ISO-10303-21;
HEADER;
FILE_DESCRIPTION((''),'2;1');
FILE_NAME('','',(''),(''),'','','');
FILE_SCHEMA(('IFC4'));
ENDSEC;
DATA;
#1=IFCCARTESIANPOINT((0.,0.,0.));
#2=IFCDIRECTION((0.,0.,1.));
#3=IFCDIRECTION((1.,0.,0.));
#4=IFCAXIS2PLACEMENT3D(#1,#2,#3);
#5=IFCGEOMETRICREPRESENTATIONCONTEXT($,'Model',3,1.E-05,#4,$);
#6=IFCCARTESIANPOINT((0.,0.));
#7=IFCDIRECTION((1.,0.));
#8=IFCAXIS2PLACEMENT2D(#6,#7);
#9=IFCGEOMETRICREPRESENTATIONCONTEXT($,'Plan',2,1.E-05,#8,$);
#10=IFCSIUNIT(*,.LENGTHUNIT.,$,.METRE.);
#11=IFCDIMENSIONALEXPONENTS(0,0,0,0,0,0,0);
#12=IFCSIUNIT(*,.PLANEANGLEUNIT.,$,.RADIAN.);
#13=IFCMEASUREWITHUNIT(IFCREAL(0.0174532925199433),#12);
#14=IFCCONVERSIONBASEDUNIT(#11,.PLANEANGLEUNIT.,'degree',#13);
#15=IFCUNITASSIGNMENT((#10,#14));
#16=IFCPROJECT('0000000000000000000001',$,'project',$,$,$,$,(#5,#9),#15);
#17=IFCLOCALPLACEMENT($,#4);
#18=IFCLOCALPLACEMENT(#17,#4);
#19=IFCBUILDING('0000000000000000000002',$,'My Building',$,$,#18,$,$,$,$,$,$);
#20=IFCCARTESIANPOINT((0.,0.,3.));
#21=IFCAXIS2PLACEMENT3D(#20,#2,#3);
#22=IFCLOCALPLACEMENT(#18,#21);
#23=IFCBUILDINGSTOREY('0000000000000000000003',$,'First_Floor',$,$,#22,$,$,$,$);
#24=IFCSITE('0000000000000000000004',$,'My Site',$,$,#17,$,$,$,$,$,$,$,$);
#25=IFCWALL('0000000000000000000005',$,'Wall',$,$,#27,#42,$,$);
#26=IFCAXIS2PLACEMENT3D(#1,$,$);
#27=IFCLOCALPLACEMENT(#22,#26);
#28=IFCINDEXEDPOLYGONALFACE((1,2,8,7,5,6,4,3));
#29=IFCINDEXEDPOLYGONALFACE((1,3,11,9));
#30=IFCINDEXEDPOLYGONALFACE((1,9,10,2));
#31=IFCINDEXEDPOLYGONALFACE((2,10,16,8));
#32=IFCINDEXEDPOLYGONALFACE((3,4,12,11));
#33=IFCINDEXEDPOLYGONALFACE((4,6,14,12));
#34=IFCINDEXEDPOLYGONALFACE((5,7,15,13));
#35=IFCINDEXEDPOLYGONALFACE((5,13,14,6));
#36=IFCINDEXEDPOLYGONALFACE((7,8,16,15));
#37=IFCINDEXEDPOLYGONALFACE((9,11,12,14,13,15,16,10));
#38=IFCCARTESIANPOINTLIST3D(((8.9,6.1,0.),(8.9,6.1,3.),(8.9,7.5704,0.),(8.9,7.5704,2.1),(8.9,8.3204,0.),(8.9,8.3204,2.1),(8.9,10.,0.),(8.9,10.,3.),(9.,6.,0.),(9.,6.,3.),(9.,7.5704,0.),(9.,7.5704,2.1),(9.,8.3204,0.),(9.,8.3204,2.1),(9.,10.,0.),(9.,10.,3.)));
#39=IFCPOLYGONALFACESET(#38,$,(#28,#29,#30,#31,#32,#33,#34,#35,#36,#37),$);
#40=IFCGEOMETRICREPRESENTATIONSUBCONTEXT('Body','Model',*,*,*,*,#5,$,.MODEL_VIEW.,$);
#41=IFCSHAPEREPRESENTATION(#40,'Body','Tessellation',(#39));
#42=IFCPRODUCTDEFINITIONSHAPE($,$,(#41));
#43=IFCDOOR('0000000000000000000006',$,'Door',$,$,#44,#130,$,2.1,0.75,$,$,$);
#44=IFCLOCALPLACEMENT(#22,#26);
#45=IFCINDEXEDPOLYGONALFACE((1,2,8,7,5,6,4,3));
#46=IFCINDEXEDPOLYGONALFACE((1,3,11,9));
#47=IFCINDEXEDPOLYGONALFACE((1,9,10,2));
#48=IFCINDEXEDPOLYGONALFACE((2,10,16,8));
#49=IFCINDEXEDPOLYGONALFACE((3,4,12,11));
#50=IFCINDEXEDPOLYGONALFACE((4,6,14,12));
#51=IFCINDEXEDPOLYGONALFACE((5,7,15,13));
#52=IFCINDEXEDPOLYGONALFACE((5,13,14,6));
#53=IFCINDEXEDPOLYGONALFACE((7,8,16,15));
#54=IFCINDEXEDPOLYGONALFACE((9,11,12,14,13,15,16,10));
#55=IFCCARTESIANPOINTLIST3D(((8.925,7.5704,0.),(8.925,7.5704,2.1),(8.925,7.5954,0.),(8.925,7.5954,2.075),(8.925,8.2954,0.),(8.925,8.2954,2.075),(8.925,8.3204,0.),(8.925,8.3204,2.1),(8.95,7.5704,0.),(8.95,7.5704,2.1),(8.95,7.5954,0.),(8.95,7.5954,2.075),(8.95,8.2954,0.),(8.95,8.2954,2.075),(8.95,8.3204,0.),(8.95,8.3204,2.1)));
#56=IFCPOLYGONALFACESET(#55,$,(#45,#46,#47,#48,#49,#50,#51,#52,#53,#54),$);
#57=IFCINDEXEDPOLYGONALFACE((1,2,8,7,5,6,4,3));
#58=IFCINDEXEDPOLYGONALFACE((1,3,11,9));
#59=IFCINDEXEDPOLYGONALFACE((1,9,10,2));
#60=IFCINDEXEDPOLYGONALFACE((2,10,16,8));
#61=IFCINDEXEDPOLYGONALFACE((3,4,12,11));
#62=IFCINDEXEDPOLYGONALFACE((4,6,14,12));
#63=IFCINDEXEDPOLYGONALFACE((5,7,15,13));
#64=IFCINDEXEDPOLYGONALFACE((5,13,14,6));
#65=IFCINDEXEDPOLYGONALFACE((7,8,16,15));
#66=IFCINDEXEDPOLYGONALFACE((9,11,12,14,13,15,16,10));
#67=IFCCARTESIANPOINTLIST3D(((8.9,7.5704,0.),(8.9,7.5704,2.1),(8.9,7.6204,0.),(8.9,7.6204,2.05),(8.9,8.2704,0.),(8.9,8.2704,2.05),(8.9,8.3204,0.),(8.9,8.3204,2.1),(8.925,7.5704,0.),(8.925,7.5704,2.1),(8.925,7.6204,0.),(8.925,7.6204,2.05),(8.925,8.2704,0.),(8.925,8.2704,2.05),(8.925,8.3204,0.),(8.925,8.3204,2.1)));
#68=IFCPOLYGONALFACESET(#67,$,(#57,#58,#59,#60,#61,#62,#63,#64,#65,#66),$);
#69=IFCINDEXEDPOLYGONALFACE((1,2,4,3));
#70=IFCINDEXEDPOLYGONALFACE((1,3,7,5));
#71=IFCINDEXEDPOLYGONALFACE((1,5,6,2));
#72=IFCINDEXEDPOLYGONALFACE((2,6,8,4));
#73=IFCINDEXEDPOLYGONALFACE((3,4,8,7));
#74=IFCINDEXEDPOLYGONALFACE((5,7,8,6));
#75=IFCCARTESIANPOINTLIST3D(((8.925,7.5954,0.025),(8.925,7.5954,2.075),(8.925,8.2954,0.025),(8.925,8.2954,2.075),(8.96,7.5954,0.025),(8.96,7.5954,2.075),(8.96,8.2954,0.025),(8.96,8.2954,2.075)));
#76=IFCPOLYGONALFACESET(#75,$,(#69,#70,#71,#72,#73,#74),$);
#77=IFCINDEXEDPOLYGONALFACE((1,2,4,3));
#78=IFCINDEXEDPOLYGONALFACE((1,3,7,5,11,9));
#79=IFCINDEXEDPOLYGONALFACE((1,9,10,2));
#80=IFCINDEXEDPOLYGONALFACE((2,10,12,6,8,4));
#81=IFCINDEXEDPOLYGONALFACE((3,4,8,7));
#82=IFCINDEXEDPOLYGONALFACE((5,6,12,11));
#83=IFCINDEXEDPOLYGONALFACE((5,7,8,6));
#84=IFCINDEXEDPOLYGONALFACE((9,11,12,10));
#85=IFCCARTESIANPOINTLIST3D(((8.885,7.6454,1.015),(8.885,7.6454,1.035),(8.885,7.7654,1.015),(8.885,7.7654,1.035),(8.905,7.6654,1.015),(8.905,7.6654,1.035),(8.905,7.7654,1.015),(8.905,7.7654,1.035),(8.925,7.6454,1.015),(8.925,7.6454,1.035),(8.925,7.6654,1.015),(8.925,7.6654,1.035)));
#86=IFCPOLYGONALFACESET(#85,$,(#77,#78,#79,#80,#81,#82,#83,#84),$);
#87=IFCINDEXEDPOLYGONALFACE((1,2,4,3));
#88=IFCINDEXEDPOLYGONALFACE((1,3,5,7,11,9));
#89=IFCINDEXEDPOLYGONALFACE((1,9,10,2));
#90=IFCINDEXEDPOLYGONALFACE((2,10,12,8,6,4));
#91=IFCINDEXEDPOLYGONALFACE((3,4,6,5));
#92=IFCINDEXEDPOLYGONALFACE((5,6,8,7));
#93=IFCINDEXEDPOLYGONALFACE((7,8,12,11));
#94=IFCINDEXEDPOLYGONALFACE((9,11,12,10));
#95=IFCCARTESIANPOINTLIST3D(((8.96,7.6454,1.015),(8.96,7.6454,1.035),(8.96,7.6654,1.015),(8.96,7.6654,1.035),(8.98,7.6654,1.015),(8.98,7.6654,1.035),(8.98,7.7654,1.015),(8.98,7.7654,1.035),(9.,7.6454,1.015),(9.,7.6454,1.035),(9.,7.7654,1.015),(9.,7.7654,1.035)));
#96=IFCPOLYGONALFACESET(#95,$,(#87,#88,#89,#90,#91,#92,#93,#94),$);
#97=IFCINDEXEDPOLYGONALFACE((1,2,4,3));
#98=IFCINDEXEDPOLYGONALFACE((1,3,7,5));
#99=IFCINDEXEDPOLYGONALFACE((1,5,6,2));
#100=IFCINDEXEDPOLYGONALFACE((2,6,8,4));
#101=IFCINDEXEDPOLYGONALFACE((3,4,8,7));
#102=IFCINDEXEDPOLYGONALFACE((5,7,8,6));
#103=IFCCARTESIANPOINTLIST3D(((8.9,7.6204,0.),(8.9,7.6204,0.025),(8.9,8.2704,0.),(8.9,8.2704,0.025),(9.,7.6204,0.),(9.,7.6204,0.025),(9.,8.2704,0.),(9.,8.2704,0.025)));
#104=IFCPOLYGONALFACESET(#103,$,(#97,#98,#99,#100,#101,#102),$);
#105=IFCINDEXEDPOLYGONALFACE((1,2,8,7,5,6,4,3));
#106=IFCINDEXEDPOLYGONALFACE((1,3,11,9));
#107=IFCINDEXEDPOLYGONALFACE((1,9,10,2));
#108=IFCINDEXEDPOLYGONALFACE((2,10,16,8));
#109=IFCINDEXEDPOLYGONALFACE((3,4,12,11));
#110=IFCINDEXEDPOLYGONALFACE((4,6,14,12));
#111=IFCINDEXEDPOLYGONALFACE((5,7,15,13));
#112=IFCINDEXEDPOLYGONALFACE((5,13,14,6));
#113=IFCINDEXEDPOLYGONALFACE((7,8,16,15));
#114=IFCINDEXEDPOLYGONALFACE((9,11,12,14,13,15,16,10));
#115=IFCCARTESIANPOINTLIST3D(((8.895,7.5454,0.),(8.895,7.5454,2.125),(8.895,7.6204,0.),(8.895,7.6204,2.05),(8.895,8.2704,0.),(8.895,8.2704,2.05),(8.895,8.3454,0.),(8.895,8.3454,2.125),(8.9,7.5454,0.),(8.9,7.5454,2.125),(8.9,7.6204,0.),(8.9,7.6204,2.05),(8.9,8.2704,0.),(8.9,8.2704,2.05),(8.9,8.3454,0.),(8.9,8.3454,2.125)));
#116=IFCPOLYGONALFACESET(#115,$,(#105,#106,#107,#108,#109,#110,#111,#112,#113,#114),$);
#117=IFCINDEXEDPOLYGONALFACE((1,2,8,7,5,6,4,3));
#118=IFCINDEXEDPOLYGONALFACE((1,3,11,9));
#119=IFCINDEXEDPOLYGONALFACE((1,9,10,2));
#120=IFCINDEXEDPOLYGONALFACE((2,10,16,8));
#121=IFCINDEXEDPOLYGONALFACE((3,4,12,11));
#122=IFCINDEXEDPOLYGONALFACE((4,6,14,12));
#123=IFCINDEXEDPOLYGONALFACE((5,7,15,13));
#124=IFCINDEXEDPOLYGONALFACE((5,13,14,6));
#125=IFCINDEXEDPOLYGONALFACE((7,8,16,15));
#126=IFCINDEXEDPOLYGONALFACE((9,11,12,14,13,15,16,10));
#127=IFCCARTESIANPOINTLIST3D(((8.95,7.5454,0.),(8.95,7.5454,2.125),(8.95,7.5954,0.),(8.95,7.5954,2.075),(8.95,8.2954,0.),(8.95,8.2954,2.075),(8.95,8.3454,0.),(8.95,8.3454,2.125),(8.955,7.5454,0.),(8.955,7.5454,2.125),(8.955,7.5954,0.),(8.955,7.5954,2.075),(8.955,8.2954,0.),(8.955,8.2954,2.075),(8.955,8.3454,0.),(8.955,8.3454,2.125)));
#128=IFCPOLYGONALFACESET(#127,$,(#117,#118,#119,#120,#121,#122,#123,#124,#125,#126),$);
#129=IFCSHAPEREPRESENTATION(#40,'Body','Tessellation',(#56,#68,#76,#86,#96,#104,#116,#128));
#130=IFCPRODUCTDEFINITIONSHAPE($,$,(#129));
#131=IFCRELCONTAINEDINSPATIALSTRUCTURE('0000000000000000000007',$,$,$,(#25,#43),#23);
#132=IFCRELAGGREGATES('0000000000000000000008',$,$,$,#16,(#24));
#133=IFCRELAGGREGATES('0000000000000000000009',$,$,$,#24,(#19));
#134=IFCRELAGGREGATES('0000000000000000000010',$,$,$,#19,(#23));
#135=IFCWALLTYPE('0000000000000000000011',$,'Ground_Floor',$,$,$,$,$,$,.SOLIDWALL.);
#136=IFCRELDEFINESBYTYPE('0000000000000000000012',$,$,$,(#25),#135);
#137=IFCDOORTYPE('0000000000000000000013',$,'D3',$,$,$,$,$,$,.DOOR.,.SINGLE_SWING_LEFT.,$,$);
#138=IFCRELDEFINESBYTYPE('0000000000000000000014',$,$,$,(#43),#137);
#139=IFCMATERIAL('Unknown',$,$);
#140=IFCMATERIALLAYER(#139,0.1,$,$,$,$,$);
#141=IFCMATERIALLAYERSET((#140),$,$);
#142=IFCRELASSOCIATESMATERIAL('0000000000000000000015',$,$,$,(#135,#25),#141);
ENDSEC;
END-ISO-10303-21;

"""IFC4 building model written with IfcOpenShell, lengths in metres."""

from ifc_helpers import new_model, entity, si_unit, converted_unit, frame, origin_with_axes, origin_2d_with_axis, place, context, subcontext, project, spatial, line, indexed_curve, outline, extrude, shape, source, transform, mapped, material, layer, layer_set, layer_usage, type_object, type_shapes, element, fill, save


model = new_model("IFC4")

# Units and contexts
model_context = context("Model", 3, precision=1e-05, world=origin_with_axes())
plan_context = context("Plan", 2, precision=1e-05, world=origin_2d_with_axis())
body_context_1 = subcontext(model_context, "Body", "Model", "MODEL_VIEW")
body_context_2 = subcontext(plan_context, "Body", "Plan", "PLAN_VIEW")
ifc_project = project(units=[si_unit("LENGTHUNIT", "METRE"), converted_unit("PLANEANGLEUNIT", "degree", entity("IfcReal", 0.0174532925199433), si_unit("PLANEANGLEUNIT", "RADIAN"), dimensions=[0, 0, 0, 0, 0, 0, 0])], contexts=[model_context, plan_context])

# Site, building, storey
site_placement = place(None, origin_with_axes())
site = spatial("IfcSite", under=ifc_project, at=site_placement, Name="My Site")
building_placement = place(site_placement, origin_with_axes())
building = spatial("IfcBuilding", under=site, at=building_placement, Name="My Building")
storey_placement = place(building_placement, frame((0.0, 0.0, 3.0), z_axis=(0.0, 0.0, 1.0), x_axis=(1.0, 0.0, 0.0)))
storey = spatial("IfcBuildingStorey", under=building, at=storey_placement, Name="First_Floor")

# Shared definitions
ifc_material = material(Name="Unknown")

# Shared definitions
ifc_layer = layer(ifc_material, 0.1)
ifc_layer_set = layer_set([ifc_layer])
wall_type = type_object("IfcWallType", Name="Ground_Floor", PredefinedType="SOLIDWALL", material=ifc_layer_set)

# Wall, opening, door
ifc_layer_usage_1 = layer_usage(ifc_layer_set, "AXIS2", "POSITIVE", 0.0)
wall_1_placement = place(storey_placement, frame((9.0, 6.0, 0.0), z_axis=(0.0, 0.0, 1.0), x_axis=(0.0, 1.0, 0.0)))
wall_1 = element("IfcWall", 1, at=wall_1_placement, inside=storey, type_object=wall_type, material=ifc_layer_usage_1, Name="Wall", context=body_context_1, shape_type="SweptSolid", body=[
    extrude(outline(indexed_curve([(0.0, 0.0), (0.1, 0.1), (4.0, 0.1), (4.0, 0.0)], segments=[line(1, 2, 3, 4, 1)])), origin_with_axes(), (0.0, 0.0, 1.0), 3.0),
])
shared_shape_1 = source(origin_with_axes(), body_context_1, "Body", "SweptSolid", [
    extrude(outline(indexed_curve([(0.0, 0.0), (0.75, 0.0), (0.75, 2.1), (0.0, 2.1)], segments=[line(1, 2, 3, 4, 1)])), frame((0.0, -0.6, 0.0), z_axis=(0.0, -1.0, 0.0), x_axis=(1.0, 0.0, 0.0)), (0.0, 0.0, -1.0), 1.2),
])
opening_1_placement = place(wall_1_placement, frame((2.3204, 0.1, 0.0), z_axis=(0.0, 0.0, 1.0), x_axis=(-1.0, 0.0, 0.0)))
opening_1 = element("IfcOpeningElement", 2, at=opening_1_placement, cuts=wall_1, PredefinedType="OPENING", context=body_context_1, shape_type="MappedRepresentation", body=[
    mapped(shared_shape_1, transform((0.0, 0.0, 0.0), x_axis=(1.0, 0.0, 0.0), y_axis=(0.0, 1.0, 0.0), z_axis=(0.0, 0.0, 1.0), scale=1.0)),
])
door_type_1 = type_object("IfcDoorType", Name="D3", OperationType="SINGLE_SWING_LEFT", PredefinedType="DOOR")
shared_shape_2 = source(origin_with_axes(), body_context_1, "Body", "SweptSolid", [
    extrude(outline(indexed_curve([(0.0, 0.0), (0.0, 2.1), (0.75, 2.1), (0.75, 0.0), (0.725, 0.0), (0.725, 2.075), (0.025, 2.075), (0.025, 0.0)], segments=[line(1, 2, 3, 4, 5, 6, 7, 8, 1)])), frame((0.0, 0.025, 0.0), z_axis=(0.0, -1.0, 0.0), x_axis=(1.0, 0.0, 0.0)), (0.0, 0.0, -1.0), 0.025),
    extrude(outline(indexed_curve([(0.0, 0.0), (0.0, 2.1), (0.75, 2.1), (0.75, 0.0), (0.7, 0.0), (0.7, 2.05), (0.05, 2.05), (0.05, 0.0)], segments=[line(1, 2, 3, 4, 5, 6, 7, 8, 1)])), frame((0.0, 0.0, 0.0), z_axis=(0.0, -1.0, 0.0), x_axis=(1.0, 0.0, 0.0)), (0.0, 0.0, -1.0), 0.025),
    extrude(outline(indexed_curve([(0.0, 0.0), (0.7, 0.0), (0.7, 0.035), (0.0, 0.035)], segments=[line(1, 2, 3, 4, 1)])), frame((0.025, 0.025, 0.025), z_axis=(0.0, 0.0, 1.0), x_axis=(1.0, 0.0, 0.0)), (0.0, 0.0, 1.0), 2.05),
    extrude(outline(indexed_curve([(0.0, 0.0), (0.0, -0.04), (-0.12, -0.04), (-0.12, -0.02), (-0.02, -0.02), (-0.02, 0.0)], segments=[line(1, 2, 3, 4, 5, 6, 1)])), frame((0.675, 0.025, 1.015), z_axis=(0.0, 0.0, 1.0), x_axis=(1.0, 0.0, 0.0)), (0.0, 0.0, 1.0), 0.02),
    extrude(outline(indexed_curve([(0.0, 0.0), (0.0, 0.04), (-0.12, 0.04), (-0.12, 0.02), (-0.02, 0.02), (-0.02, 0.0)], segments=[line(1, 2, 3, 4, 5, 6, 1)])), frame((0.675, 0.06, 1.015), z_axis=(0.0, 0.0, 1.0), x_axis=(1.0, 0.0, 0.0)), (0.0, 0.0, 1.0), 0.02),
    extrude(outline(indexed_curve([(0.0, 0.0), (0.65, 0.0), (0.65, 0.1), (0.0, 0.1)], segments=[line(1, 2, 3, 4, 1)])), frame((0.05, 0.0, 0.0), z_axis=(0.0, 0.0, 1.0), x_axis=(1.0, 0.0, 0.0)), (0.0, 0.0, 1.0), 0.025),
    extrude(outline(indexed_curve([(0.0, 0.0), (0.0, 2.125), (0.8, 2.125), (0.8, 0.0), (0.725, 0.0), (0.725, 2.05), (0.075, 2.05), (0.075, 0.0)], segments=[line(1, 2, 3, 4, 5, 6, 7, 8, 1)])), frame((-0.025, -0.005, 0.0), z_axis=(0.0, -1.0, 0.0), x_axis=(1.0, 0.0, 0.0)), (0.0, 0.0, -1.0), 0.005),
    extrude(outline(indexed_curve([(0.0, 0.0), (0.0, 2.125), (0.8, 2.125), (0.8, 0.0), (0.75, 0.0), (0.75, 2.075), (0.05, 2.075), (0.05, 0.0)], segments=[line(1, 2, 3, 4, 5, 6, 7, 8, 1)])), frame((-0.025, 0.05, 0.0), z_axis=(0.0, -1.0, 0.0), x_axis=(1.0, 0.0, 0.0)), (0.0, 0.0, -1.0), 0.005),
])
shared_shape_3 = source(origin_with_axes(), body_context_2, "Body", "Curve2D", [
    entity("IfcIndexedPolyCurve", entity("IfcCartesianPointList2D", [[0.0, 0.0], [0.0, 0.05], [0.025, 0.05], [0.025, 0.025], [0.05, 0.025], [0.05, 0.0]]), [entity("IfcLineIndex", [1, 2, 3, 4, 5, 6, 1])]),
    entity("IfcIndexedPolyCurve", entity("IfcCartesianPointList2D", [[0.75, 0.0], [0.75, 0.05], [0.725, 0.05], [0.725, 0.025], [0.7, 0.025], [0.7, 0.0]]), [entity("IfcLineIndex", [1, 2, 3, 4, 5, 6, 1])]),
    entity("IfcTrimmedCurve", entity("IfcEllipse", entity("IfcAxis2Placement2D", entity("IfcCartesianPoint", [0.06, 0.05]), entity("IfcDirection", [1.0, 0.0])), 0.665, 0.7), [entity("IfcCartesianPoint", [0.725, 0.05])], [entity("IfcCartesianPoint", [0.06, 0.75])], True, "CARTESIAN"),
    entity("IfcIndexedPolyCurve", entity("IfcCartesianPointList2D", [[0.025, 0.05], [0.06, 0.05], [0.06, 0.75], [0.025, 0.75]]), [entity("IfcLineIndex", [1, 2, 3, 4, 1])]),
])
type_shapes(door_type_1, [shared_shape_2, shared_shape_3])
door_1_placement = place(opening_1_placement, origin_with_axes())
door_1 = element("IfcDoor", 3, at=door_1_placement, inside=storey, type_object=door_type_1, Name="Door", OverallHeight=2.1, OverallWidth=0.75, shapes=[
    shape(body_context_1, "Body", "MappedRepresentation", [mapped(shared_shape_2, transform((0.0, 0.0, 0.0), x_axis=(1.0, 0.0, 0.0), y_axis=(0.0, 1.0, 0.0), z_axis=(0.0, 0.0, 1.0), scale=1.0))]),
    shape(body_context_2, "Body", "MappedRepresentation", [mapped(shared_shape_3, transform((0.0, 0.0, 0.0), x_axis=(1.0, 0.0, 0.0), y_axis=(0.0, 1.0, 0.0), z_axis=(0.0, 0.0, 1.0), scale=1.0))]),
])
fill(opening_1, door_1)

save(model, "model.ifc")
